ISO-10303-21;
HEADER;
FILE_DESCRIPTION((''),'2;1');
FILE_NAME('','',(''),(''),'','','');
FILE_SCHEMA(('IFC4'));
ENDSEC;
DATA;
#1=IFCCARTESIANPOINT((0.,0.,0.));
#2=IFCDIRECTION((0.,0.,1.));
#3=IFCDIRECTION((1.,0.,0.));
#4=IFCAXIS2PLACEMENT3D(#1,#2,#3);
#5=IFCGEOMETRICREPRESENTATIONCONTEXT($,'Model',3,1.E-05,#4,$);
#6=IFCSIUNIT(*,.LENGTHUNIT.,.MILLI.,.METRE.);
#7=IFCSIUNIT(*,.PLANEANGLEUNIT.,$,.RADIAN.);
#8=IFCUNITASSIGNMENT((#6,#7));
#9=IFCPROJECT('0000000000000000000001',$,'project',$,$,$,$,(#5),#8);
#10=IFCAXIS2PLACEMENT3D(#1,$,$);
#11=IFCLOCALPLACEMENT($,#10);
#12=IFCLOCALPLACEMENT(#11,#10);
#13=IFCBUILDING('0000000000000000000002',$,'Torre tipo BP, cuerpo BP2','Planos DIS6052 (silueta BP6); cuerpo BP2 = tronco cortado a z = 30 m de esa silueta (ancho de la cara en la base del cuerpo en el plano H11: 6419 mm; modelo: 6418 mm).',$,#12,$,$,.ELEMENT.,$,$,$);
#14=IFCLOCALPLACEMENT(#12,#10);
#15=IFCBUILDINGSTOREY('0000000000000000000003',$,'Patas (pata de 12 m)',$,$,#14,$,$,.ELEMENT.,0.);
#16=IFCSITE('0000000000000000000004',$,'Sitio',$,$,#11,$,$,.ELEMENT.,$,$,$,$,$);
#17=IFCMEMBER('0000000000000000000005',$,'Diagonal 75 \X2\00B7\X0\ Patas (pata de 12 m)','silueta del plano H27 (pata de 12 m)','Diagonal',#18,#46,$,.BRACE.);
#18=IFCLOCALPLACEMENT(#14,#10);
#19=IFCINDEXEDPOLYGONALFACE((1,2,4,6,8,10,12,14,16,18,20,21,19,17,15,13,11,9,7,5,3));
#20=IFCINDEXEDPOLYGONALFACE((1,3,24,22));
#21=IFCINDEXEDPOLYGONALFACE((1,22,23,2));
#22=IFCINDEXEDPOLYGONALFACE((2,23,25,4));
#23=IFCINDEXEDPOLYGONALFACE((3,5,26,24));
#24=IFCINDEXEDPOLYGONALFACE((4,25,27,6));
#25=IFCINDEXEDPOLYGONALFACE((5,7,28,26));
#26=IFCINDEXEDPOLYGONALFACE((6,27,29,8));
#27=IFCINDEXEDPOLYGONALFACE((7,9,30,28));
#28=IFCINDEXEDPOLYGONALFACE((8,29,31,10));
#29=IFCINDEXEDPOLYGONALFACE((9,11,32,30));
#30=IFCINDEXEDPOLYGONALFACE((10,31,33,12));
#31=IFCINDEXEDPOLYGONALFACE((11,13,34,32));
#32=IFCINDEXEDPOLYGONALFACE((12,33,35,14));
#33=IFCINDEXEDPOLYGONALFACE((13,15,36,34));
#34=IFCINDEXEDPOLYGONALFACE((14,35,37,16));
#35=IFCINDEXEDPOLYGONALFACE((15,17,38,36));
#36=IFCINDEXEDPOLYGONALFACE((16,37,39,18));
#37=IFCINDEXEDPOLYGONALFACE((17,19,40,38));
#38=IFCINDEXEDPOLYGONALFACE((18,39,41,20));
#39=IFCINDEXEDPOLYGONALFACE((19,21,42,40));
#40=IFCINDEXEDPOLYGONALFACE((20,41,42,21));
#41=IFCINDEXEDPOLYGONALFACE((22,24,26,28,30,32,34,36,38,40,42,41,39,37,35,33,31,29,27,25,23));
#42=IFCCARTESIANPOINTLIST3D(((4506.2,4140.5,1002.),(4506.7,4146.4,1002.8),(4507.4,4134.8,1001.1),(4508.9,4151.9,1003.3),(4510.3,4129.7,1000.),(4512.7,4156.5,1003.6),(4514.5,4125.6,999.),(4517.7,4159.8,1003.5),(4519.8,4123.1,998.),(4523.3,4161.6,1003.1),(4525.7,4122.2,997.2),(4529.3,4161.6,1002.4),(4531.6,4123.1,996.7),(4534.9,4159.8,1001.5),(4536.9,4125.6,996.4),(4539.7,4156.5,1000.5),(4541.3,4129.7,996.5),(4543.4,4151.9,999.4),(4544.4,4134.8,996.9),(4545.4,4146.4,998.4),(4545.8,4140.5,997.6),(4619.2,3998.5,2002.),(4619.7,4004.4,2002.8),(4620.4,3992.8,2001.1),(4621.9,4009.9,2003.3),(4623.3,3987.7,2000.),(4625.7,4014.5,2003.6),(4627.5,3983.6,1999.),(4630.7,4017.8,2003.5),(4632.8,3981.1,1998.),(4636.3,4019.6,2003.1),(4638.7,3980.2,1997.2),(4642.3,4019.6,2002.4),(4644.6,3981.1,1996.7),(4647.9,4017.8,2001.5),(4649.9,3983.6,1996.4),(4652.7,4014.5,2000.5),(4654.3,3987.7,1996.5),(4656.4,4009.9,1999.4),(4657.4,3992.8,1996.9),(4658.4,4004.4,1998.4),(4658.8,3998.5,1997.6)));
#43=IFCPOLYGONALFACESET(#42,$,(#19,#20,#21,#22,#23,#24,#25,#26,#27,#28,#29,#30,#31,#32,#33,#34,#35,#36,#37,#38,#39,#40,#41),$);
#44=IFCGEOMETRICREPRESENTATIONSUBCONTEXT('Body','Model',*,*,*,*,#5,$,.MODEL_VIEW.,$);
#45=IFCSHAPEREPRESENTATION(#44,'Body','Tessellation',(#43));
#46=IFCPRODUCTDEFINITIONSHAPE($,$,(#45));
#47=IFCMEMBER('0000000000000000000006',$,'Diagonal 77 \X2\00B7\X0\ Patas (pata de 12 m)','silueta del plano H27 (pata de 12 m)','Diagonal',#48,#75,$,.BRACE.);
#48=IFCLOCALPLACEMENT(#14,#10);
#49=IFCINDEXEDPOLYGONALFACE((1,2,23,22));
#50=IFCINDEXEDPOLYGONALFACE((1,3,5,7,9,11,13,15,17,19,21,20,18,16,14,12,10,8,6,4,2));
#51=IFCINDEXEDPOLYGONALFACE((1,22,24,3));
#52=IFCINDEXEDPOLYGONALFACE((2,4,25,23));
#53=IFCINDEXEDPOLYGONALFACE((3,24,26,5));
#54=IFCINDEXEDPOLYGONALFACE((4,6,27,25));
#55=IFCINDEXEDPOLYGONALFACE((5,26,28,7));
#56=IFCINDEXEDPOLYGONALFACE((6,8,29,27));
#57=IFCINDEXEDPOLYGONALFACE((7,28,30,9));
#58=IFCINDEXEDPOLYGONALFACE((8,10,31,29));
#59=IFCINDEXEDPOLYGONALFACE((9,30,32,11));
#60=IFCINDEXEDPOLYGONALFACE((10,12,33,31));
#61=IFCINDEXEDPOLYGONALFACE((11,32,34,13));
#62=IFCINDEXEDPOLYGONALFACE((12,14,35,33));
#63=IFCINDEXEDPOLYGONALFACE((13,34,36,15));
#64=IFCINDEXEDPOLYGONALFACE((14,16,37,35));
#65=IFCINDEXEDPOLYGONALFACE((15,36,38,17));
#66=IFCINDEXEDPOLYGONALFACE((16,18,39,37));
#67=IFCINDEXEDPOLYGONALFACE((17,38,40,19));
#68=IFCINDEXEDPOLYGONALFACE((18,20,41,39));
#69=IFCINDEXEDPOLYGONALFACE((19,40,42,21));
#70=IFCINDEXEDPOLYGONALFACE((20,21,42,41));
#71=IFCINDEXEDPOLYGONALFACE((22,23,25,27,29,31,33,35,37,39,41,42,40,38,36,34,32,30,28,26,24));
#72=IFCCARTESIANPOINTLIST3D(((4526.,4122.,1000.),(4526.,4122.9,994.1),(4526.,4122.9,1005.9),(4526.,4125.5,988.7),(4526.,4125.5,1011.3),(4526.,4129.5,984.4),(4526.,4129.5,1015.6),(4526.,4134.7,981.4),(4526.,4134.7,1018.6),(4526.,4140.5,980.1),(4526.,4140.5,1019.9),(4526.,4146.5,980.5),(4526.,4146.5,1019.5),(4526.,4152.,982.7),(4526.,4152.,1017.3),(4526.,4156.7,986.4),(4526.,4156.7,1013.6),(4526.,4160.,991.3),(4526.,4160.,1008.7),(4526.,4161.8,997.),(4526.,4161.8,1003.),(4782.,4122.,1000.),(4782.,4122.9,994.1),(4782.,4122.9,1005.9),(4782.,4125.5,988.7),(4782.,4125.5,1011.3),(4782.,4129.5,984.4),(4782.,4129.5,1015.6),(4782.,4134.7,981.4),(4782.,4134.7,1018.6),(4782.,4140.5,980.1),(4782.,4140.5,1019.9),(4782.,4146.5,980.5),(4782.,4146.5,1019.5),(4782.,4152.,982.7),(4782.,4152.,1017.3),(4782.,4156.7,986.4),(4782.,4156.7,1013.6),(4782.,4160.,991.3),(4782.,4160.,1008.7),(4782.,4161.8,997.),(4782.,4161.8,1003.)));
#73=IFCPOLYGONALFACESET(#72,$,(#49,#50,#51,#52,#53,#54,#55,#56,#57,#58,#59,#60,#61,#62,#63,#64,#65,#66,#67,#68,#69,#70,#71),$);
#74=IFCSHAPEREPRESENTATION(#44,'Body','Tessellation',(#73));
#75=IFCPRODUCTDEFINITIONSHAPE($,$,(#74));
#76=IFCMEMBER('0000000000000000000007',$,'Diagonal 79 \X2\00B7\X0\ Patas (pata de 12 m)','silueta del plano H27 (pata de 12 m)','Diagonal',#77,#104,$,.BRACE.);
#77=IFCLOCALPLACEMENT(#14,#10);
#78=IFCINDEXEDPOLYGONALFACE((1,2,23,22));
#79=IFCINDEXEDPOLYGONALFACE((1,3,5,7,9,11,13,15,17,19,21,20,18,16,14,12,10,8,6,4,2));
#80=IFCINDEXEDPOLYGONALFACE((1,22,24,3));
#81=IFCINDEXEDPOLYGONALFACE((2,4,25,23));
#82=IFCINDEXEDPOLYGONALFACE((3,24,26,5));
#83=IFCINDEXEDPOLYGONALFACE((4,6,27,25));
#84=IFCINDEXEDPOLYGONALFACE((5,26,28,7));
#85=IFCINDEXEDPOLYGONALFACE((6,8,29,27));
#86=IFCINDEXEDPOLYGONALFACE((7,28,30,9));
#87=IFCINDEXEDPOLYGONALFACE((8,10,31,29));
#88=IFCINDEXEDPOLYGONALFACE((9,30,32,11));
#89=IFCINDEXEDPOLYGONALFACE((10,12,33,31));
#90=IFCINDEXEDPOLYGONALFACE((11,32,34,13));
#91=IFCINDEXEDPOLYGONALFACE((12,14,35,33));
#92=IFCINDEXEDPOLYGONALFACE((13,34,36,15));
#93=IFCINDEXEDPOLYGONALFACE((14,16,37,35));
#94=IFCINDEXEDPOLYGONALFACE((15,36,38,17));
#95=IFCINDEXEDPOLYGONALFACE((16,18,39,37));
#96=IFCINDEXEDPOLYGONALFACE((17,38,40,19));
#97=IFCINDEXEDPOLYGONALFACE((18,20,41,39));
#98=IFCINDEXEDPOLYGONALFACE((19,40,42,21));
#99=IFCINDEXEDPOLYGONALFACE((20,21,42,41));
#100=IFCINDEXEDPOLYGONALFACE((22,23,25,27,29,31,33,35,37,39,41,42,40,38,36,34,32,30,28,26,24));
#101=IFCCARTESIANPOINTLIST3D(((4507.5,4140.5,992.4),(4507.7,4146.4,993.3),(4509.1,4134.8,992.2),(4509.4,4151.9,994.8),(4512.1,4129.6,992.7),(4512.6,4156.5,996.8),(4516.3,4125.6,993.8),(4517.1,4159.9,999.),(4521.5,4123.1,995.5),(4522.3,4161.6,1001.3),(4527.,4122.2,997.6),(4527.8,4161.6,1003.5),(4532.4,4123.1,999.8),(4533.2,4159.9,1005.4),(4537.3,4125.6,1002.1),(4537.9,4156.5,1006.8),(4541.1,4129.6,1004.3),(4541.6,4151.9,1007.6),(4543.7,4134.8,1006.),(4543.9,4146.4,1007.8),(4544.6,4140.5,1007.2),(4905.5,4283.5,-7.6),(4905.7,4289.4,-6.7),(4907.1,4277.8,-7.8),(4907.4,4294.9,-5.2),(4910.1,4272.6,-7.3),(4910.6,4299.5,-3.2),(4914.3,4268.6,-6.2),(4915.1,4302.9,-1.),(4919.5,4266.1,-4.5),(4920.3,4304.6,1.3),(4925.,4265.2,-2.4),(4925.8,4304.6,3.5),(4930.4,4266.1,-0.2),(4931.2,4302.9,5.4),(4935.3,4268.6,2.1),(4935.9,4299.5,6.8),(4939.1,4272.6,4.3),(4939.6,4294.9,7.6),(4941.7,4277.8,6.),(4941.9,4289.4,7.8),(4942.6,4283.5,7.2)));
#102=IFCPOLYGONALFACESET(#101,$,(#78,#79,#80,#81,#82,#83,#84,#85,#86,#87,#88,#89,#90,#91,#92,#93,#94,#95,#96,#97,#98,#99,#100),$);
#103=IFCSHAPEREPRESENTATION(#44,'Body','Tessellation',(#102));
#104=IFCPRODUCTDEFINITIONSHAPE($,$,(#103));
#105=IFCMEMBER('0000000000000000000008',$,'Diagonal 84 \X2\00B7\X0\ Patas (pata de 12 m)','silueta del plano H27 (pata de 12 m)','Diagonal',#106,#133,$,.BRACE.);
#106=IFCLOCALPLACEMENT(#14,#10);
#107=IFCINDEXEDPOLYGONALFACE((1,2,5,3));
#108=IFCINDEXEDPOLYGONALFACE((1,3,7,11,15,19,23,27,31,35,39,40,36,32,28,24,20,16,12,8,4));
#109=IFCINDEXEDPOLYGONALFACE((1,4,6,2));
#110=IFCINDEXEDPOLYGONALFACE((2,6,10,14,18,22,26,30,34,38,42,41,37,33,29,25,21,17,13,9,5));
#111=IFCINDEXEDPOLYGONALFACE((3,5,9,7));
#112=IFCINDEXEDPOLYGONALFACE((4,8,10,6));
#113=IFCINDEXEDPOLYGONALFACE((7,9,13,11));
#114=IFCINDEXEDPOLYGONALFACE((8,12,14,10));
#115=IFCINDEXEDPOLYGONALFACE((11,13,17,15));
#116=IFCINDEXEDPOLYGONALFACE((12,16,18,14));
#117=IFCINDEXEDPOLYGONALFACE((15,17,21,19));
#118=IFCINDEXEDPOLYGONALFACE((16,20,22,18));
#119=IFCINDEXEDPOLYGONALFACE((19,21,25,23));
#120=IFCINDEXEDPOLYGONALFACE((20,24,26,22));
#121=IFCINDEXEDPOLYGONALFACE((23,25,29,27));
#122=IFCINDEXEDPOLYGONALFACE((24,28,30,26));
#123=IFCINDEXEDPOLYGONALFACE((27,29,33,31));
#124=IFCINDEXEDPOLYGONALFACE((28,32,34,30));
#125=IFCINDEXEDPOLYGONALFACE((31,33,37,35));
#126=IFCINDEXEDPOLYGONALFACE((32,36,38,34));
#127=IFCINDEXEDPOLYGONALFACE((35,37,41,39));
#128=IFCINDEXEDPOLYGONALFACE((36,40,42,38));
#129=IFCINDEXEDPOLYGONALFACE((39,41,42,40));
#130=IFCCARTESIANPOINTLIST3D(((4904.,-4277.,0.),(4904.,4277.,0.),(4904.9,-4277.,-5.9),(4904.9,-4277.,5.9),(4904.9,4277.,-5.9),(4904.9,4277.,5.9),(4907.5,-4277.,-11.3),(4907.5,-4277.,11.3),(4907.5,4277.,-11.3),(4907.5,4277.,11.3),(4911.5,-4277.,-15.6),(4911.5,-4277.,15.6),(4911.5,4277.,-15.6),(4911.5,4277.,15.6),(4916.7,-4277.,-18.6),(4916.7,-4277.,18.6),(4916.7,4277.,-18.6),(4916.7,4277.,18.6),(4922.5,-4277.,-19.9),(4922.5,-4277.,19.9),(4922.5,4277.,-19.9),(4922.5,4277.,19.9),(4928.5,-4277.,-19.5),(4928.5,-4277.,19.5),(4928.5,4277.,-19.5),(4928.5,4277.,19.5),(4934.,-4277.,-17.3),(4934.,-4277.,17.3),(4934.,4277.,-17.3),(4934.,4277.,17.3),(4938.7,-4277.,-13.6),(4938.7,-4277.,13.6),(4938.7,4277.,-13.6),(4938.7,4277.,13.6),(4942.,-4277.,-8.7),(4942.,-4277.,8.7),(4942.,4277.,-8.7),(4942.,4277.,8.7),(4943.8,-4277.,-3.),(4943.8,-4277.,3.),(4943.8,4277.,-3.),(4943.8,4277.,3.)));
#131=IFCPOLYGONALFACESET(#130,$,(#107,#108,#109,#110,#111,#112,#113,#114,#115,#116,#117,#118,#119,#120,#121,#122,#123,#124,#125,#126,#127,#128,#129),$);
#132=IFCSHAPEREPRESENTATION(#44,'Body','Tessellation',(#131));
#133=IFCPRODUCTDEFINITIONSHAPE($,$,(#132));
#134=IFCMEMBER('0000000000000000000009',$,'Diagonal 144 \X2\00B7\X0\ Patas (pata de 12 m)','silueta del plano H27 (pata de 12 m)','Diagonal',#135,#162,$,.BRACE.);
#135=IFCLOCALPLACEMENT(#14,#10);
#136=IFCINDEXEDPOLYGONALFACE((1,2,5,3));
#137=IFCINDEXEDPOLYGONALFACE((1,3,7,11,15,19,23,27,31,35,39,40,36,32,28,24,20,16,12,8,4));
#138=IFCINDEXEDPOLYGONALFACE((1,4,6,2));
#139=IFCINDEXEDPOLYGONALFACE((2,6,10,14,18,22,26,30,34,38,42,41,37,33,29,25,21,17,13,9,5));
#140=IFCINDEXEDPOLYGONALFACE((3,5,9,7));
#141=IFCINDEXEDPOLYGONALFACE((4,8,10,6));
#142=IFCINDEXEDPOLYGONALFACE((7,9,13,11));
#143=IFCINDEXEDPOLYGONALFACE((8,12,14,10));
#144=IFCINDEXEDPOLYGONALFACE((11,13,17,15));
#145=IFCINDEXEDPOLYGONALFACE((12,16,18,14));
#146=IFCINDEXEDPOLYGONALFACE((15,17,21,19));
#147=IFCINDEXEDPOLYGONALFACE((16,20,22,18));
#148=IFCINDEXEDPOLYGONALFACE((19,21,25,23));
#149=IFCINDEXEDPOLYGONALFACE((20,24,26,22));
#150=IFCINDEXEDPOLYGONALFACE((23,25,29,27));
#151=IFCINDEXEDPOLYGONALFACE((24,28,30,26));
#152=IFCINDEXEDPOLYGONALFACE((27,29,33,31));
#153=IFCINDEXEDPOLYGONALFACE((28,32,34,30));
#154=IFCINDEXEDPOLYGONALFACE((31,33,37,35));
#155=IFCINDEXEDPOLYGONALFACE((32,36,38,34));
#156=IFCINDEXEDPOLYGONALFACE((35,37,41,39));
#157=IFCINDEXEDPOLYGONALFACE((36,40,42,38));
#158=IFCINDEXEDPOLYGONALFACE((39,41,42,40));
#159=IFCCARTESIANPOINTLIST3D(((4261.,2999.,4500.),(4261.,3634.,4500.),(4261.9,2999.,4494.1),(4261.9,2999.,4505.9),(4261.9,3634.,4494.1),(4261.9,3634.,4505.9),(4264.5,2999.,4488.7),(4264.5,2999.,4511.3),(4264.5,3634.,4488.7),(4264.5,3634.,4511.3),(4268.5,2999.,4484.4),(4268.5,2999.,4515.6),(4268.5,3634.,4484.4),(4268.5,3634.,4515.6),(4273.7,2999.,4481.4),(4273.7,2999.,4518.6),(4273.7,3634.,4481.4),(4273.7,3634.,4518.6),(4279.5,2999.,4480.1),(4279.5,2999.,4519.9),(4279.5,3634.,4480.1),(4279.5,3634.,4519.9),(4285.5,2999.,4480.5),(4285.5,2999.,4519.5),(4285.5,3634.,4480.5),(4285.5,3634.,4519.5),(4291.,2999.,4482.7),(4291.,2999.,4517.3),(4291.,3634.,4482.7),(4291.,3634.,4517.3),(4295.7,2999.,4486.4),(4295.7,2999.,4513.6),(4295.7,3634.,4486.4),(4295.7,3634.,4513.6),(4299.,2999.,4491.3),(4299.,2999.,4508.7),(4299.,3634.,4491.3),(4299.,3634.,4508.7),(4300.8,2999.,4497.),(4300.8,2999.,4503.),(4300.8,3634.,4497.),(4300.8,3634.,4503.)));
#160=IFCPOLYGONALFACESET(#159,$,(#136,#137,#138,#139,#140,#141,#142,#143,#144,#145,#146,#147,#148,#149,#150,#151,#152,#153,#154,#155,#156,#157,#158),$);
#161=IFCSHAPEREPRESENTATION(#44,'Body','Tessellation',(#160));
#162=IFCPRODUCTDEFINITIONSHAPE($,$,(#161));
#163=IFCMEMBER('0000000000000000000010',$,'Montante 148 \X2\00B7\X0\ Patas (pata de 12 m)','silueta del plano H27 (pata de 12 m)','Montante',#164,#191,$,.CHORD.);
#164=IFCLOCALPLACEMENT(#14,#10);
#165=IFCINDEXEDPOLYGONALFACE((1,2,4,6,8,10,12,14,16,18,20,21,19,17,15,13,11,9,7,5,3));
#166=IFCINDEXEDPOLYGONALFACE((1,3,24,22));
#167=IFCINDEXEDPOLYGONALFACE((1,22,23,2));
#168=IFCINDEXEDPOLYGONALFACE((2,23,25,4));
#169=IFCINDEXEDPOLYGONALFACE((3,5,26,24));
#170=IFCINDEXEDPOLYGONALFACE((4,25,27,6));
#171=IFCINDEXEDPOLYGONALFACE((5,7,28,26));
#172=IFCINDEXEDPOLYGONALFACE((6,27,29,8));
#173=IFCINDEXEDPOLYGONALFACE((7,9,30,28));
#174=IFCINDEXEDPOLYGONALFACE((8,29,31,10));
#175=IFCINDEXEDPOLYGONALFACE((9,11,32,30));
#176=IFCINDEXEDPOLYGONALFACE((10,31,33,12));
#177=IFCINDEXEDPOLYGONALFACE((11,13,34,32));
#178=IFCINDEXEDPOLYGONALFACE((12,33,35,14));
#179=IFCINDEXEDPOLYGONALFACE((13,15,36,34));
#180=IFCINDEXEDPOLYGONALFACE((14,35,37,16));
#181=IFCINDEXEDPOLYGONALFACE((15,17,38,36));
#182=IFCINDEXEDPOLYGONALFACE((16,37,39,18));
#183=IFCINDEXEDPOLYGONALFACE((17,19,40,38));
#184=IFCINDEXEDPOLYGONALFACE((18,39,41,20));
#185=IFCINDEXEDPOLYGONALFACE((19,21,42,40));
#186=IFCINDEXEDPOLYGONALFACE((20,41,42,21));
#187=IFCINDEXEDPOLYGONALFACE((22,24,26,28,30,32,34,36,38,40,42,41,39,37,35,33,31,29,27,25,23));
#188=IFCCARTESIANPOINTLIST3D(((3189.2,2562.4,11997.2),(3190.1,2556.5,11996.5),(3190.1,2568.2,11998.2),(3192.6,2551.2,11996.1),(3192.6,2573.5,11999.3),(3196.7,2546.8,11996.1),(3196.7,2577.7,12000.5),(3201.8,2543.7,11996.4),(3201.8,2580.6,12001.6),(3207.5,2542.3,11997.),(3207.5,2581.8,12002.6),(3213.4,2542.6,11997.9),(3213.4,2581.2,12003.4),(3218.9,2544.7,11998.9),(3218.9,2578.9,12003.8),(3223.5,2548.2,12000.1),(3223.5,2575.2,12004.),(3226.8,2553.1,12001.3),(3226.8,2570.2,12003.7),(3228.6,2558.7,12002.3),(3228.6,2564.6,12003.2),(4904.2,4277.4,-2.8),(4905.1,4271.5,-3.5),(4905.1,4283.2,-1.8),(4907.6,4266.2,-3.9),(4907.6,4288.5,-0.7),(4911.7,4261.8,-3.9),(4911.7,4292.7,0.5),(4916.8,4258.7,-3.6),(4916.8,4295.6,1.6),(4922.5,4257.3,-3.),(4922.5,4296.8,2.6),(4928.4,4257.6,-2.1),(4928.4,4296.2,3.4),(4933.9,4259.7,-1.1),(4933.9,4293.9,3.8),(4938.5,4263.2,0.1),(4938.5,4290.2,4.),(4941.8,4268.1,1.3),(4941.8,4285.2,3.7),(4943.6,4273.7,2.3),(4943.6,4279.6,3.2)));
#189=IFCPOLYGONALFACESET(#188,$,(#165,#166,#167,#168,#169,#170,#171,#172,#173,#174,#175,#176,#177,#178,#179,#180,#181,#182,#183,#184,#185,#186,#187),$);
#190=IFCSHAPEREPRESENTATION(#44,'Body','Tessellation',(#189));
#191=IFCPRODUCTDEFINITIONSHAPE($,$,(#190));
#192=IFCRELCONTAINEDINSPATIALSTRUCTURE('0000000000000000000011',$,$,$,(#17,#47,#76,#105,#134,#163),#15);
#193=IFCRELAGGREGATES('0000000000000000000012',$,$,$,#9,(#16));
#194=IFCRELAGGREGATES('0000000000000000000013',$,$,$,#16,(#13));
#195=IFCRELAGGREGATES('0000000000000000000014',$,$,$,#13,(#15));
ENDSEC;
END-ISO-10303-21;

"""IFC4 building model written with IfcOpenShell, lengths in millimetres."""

from ifc_helpers import new_model, si_unit, frame, origin, origin_with_axes, place, context, subcontext, project, spatial, circle, extrude, element, save


model = new_model("IFC4")

# Units and contexts
model_context = context("Model", 3, precision=1e-05, world=origin_with_axes())
body_context = subcontext(model_context, "Body", "Model", "MODEL_VIEW")
ifc_project = project(units=[si_unit("LENGTHUNIT", "METRE", prefix="MILLI"), si_unit("PLANEANGLEUNIT", "RADIAN")], contexts=[model_context])

# Site, building, storey
site_placement = place(None, origin())
site = spatial("IfcSite", under=ifc_project, at=site_placement, Name="Sitio", CompositionType="ELEMENT")
building_placement = place(site_placement, origin())
building = spatial("IfcBuilding", under=site, at=building_placement, Name="Torre tipo BP, cuerpo BP2", Description="Planos DIS6052 (silueta BP6); cuerpo BP2 = tronco cortado a z = 30 m de esa silueta (ancho de la cara en la base del cuerpo en el plano H11: 6419 mm; modelo: 6418 mm).", CompositionType="ELEMENT")
storey_placement = place(building_placement, origin())
storey = spatial("IfcBuildingStorey", under=building, at=storey_placement, Name="Patas (pata de 12 m)", CompositionType="ELEMENT", Elevation=0.0)

# Members
member_1_placement = place(storey_placement, frame((4526.0, 4142.0, 1000.0), z_axis=(0.111184, -0.139718, 0.983929), x_axis=(-0.015688, -0.990191, -0.138834)))
element("IfcMember", 1, at=member_1_placement, inside=storey, Name="Diagonal 75 · Patas (pata de 12 m)", Description="silueta del plano H27 (pata de 12 m)", ObjectType="Diagonal", PredefinedType="BRACE", context=body_context, shape_type="SweptSolid", body=[
    extrude(circle(Radius=20.0), None, (0.0, 0.0, 1.0), 1016.3),
])
member_2_placement = place(storey_placement, frame((4782.0, 4142.0, 1000.0), z_axis=(-1.0, 0.0, 0.0), x_axis=(0.0, -1.0, 0.0)))
element("IfcMember", 2, at=member_2_placement, inside=storey, Name="Diagonal 77 · Patas (pata de 12 m)", Description="silueta del plano H27 (pata de 12 m)", ObjectType="Diagonal", PredefinedType="BRACE", context=body_context, shape_type="SweptSolid", body=[
    extrude(circle(Radius=20.0), None, (0.0, 0.0, 1.0), 256.0),
])
member_3_placement = place(storey_placement, frame((4924.0, 4285.0, 0.0), z_axis=(-0.366567, -0.131706, 0.921022), x_axis=(0.048703, -0.991289, -0.12237)))
element("IfcMember", 3, at=member_3_placement, inside=storey, Name="Diagonal 79 · Patas (pata de 12 m)", Description="silueta del plano H27 (pata de 12 m)", ObjectType="Diagonal", PredefinedType="BRACE", context=body_context, shape_type="SweptSolid", body=[
    extrude(circle(Radius=20.0), None, (0.0, 0.0, 1.0), 1085.7),
])
member_4_placement = place(storey_placement, frame((4924.0, 4277.0, 0.0), z_axis=(0.0, -1.0, 0.0), x_axis=(-1.0, 0.0, 0.0)))
element("IfcMember", 4, at=member_4_placement, inside=storey, Name="Diagonal 84 · Patas (pata de 12 m)", Description="silueta del plano H27 (pata de 12 m)", ObjectType="Diagonal", PredefinedType="BRACE", context=body_context, shape_type="SweptSolid", body=[
    extrude(circle(Radius=20.0), None, (0.0, 0.0, 1.0), 8554.0),
])
member_5_placement = place(storey_placement, frame((4281.0, 3634.0, 4500.0), z_axis=(0.0, -1.0, 0.0), x_axis=(-1.0, 0.0, 0.0)))
element("IfcMember", 5, at=member_5_placement, inside=storey, Name="Diagonal 144 · Patas (pata de 12 m)", Description="silueta del plano H27 (pata de 12 m)", ObjectType="Diagonal", PredefinedType="BRACE", context=body_context, shape_type="SweptSolid", body=[
    extrude(circle(Radius=20.0), None, (0.0, 0.0, 1.0), 635.0),
])
member_6_placement = place(storey_placement, frame((4924.0, 4277.0, 0.0), z_axis=(-0.140084, -0.140084, 0.98018), x_axis=(-0.99014, 0.019819, -0.138675)))
element("IfcMember", 6, at=member_6_placement, inside=storey, Name="Montante 148 · Patas (pata de 12 m)", Description="silueta del plano H27 (pata de 12 m)", ObjectType="Montante", PredefinedType="CHORD", context=body_context, shape_type="SweptSolid", body=[
    extrude(circle(Radius=20.0), None, (0.0, 0.0, 1.0), 12242.6),
])

save(model, "model.ifc")
